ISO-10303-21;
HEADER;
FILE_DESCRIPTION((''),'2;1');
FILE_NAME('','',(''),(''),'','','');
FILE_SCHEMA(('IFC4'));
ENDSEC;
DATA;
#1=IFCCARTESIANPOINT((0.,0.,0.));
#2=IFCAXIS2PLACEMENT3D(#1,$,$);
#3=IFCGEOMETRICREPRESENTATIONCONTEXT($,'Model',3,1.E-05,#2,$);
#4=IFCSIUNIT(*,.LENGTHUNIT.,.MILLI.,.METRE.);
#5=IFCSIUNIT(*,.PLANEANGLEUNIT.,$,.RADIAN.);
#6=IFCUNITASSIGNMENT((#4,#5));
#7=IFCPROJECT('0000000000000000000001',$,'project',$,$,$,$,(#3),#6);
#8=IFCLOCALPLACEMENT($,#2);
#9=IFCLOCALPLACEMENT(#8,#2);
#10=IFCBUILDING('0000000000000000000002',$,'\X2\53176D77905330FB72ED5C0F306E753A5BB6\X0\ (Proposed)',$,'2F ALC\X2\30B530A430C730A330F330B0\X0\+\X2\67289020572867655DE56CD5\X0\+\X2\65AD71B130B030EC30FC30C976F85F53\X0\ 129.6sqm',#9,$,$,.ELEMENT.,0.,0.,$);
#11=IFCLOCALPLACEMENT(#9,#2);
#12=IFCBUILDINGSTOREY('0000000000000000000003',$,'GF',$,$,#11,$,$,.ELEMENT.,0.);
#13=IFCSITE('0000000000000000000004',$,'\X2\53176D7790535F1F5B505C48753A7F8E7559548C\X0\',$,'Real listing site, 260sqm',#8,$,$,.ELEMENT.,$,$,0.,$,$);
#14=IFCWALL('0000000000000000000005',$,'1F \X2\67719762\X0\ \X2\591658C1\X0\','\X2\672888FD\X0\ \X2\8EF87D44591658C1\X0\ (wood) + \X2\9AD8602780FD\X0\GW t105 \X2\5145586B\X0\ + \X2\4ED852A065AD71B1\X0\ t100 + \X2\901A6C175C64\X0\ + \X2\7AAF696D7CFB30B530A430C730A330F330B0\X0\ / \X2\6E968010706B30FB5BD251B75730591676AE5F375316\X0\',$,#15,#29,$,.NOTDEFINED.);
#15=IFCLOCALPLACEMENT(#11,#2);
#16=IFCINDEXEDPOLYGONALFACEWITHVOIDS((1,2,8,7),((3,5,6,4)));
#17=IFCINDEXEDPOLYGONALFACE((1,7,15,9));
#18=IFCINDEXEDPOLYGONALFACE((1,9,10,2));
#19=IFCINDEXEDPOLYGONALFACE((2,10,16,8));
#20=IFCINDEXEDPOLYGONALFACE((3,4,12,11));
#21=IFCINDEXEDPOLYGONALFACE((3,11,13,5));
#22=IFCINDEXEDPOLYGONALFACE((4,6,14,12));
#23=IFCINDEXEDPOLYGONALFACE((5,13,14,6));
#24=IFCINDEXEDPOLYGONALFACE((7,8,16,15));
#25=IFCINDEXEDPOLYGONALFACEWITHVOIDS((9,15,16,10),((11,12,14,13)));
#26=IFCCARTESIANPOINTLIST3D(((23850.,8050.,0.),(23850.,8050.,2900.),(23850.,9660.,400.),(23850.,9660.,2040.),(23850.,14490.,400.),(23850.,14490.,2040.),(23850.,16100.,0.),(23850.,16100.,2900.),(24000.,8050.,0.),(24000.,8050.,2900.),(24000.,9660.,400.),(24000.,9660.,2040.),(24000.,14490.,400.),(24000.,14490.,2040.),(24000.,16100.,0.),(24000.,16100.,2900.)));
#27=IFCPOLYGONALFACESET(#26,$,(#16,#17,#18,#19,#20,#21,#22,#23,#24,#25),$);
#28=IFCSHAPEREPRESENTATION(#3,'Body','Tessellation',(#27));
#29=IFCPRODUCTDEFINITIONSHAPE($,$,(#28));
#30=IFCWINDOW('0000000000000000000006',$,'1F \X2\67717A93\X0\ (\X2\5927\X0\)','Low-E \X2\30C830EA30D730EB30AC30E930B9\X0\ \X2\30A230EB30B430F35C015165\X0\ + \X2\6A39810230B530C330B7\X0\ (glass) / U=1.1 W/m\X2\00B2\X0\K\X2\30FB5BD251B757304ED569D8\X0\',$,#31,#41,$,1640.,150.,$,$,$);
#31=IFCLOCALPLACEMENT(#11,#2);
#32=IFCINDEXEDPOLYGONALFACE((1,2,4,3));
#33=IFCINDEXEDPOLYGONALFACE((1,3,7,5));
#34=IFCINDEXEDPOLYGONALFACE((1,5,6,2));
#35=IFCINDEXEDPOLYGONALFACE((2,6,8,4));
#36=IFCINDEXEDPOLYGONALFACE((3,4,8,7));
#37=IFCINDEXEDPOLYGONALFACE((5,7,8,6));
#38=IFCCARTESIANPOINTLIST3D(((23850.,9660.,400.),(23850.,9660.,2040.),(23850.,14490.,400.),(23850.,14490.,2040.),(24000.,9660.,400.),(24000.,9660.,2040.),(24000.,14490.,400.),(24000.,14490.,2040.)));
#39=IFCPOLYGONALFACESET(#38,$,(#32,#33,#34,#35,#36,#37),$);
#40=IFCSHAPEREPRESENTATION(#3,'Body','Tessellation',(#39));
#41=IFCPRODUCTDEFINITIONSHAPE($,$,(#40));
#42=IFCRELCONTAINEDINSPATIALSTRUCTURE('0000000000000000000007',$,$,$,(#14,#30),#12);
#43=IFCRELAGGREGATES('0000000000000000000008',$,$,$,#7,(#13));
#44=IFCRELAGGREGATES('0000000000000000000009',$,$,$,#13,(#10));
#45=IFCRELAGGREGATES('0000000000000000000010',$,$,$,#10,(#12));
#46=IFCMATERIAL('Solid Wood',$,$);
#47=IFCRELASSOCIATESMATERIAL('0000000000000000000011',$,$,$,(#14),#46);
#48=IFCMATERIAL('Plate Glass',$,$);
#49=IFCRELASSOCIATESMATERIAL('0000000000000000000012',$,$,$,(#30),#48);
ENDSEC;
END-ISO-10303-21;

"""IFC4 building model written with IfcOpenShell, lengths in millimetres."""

from ifc_helpers import new_model, si_unit, frame, frame_2d, origin, place, context, project, spatial, rectangle, extrude, material, element, fill, save


model = new_model("IFC4")

# Units and contexts
model_context = context("Model", 3, precision=1e-05, world=origin())
ifc_project = project(units=[si_unit("LENGTHUNIT", "METRE", prefix="MILLI"), si_unit("PLANEANGLEUNIT", "RADIAN")], contexts=[model_context])

# Site, building, storey
site_placement = place(None, origin())
site = spatial("IfcSite", under=ifc_project, at=site_placement, Name="北海道弟子屈町美留和", ObjectType="Real listing site, 260sqm", CompositionType="ELEMENT", RefElevation=0.0)
building_placement = place(site_placement, origin())
building = spatial("IfcBuilding", under=site, at=building_placement, Name="北海道・狭小の町家 (Proposed)", ObjectType="2F ALCサイディング+木造在来工法+断熱グレード相当 129.6sqm", CompositionType="ELEMENT", ElevationOfRefHeight=0.0, ElevationOfTerrain=0.0)
storey_placement = place(building_placement, origin())
storey = spatial("IfcBuildingStorey", under=building, at=storey_placement, Name="GF", CompositionType="ELEMENT", Elevation=0.0)

# Shared definitions
ifc_material_1 = material(Name="Solid Wood")

# Wall, opening, window
wall_1_placement = place(storey_placement, frame((11925.0, 4025.0, 0.0)))
wall_1 = element("IfcWall", 1, at=wall_1_placement, inside=storey, material=ifc_material_1, Name="1F 東面 外壁", Description="木製 軸組外壁 (wood) + 高性能GW t105 充填 + 付加断熱 t100 + 通気層 + 窯業系サイディング / 準耐火・寒冷地外皮強化", PredefinedType="NOTDEFINED", context=model_context, shape_type="SweptSolid", body=[
    extrude(rectangle(XDim=150.0, YDim=8050.0, at=frame_2d((75.0, 4025.0))), frame((11925.0, 4025.0, 0.0)), (0.0, 0.0, 1.0), 2900.0),
])
opening_1_placement = place(storey_placement, frame((11925.0, 4830.0, 200.0)))
opening_1 = element("IfcOpeningElement", 2, at=opening_1_placement, cuts=wall_1, PredefinedType="NOTDEFINED", context=model_context, shape_type="SweptSolid", body=[
    extrude(rectangle(XDim=150.0, YDim=4830.0, at=frame_2d((75.0, 2415.0))), frame((11925.0, 4830.0, 200.0)), (0.0, 0.0, 1.0), 1640.0),
])
ifc_material_2 = material(Name="Plate Glass")
window_1_placement = place(storey_placement, frame((11925.0, 4830.0, 200.0)))
window_1 = element("IfcWindow", 3, at=window_1_placement, inside=storey, material=ifc_material_2, Name="1F 東窓 (大)", Description="Low-E トリプルガラス アルゴン封入 + 樹脂サッシ (glass) / U=1.1 W/m²K・寒冷地仕様", OverallHeight=1640.0, OverallWidth=150.0, context=model_context, shape_type="SweptSolid", body=[
    extrude(rectangle(XDim=150.0, YDim=4830.0, at=frame_2d((75.0, 2415.0))), frame((11925.0, 4830.0, 200.0)), (0.0, 0.0, 1.0), 1640.0),
])
fill(opening_1, window_1)

save(model, "model.ifc")
